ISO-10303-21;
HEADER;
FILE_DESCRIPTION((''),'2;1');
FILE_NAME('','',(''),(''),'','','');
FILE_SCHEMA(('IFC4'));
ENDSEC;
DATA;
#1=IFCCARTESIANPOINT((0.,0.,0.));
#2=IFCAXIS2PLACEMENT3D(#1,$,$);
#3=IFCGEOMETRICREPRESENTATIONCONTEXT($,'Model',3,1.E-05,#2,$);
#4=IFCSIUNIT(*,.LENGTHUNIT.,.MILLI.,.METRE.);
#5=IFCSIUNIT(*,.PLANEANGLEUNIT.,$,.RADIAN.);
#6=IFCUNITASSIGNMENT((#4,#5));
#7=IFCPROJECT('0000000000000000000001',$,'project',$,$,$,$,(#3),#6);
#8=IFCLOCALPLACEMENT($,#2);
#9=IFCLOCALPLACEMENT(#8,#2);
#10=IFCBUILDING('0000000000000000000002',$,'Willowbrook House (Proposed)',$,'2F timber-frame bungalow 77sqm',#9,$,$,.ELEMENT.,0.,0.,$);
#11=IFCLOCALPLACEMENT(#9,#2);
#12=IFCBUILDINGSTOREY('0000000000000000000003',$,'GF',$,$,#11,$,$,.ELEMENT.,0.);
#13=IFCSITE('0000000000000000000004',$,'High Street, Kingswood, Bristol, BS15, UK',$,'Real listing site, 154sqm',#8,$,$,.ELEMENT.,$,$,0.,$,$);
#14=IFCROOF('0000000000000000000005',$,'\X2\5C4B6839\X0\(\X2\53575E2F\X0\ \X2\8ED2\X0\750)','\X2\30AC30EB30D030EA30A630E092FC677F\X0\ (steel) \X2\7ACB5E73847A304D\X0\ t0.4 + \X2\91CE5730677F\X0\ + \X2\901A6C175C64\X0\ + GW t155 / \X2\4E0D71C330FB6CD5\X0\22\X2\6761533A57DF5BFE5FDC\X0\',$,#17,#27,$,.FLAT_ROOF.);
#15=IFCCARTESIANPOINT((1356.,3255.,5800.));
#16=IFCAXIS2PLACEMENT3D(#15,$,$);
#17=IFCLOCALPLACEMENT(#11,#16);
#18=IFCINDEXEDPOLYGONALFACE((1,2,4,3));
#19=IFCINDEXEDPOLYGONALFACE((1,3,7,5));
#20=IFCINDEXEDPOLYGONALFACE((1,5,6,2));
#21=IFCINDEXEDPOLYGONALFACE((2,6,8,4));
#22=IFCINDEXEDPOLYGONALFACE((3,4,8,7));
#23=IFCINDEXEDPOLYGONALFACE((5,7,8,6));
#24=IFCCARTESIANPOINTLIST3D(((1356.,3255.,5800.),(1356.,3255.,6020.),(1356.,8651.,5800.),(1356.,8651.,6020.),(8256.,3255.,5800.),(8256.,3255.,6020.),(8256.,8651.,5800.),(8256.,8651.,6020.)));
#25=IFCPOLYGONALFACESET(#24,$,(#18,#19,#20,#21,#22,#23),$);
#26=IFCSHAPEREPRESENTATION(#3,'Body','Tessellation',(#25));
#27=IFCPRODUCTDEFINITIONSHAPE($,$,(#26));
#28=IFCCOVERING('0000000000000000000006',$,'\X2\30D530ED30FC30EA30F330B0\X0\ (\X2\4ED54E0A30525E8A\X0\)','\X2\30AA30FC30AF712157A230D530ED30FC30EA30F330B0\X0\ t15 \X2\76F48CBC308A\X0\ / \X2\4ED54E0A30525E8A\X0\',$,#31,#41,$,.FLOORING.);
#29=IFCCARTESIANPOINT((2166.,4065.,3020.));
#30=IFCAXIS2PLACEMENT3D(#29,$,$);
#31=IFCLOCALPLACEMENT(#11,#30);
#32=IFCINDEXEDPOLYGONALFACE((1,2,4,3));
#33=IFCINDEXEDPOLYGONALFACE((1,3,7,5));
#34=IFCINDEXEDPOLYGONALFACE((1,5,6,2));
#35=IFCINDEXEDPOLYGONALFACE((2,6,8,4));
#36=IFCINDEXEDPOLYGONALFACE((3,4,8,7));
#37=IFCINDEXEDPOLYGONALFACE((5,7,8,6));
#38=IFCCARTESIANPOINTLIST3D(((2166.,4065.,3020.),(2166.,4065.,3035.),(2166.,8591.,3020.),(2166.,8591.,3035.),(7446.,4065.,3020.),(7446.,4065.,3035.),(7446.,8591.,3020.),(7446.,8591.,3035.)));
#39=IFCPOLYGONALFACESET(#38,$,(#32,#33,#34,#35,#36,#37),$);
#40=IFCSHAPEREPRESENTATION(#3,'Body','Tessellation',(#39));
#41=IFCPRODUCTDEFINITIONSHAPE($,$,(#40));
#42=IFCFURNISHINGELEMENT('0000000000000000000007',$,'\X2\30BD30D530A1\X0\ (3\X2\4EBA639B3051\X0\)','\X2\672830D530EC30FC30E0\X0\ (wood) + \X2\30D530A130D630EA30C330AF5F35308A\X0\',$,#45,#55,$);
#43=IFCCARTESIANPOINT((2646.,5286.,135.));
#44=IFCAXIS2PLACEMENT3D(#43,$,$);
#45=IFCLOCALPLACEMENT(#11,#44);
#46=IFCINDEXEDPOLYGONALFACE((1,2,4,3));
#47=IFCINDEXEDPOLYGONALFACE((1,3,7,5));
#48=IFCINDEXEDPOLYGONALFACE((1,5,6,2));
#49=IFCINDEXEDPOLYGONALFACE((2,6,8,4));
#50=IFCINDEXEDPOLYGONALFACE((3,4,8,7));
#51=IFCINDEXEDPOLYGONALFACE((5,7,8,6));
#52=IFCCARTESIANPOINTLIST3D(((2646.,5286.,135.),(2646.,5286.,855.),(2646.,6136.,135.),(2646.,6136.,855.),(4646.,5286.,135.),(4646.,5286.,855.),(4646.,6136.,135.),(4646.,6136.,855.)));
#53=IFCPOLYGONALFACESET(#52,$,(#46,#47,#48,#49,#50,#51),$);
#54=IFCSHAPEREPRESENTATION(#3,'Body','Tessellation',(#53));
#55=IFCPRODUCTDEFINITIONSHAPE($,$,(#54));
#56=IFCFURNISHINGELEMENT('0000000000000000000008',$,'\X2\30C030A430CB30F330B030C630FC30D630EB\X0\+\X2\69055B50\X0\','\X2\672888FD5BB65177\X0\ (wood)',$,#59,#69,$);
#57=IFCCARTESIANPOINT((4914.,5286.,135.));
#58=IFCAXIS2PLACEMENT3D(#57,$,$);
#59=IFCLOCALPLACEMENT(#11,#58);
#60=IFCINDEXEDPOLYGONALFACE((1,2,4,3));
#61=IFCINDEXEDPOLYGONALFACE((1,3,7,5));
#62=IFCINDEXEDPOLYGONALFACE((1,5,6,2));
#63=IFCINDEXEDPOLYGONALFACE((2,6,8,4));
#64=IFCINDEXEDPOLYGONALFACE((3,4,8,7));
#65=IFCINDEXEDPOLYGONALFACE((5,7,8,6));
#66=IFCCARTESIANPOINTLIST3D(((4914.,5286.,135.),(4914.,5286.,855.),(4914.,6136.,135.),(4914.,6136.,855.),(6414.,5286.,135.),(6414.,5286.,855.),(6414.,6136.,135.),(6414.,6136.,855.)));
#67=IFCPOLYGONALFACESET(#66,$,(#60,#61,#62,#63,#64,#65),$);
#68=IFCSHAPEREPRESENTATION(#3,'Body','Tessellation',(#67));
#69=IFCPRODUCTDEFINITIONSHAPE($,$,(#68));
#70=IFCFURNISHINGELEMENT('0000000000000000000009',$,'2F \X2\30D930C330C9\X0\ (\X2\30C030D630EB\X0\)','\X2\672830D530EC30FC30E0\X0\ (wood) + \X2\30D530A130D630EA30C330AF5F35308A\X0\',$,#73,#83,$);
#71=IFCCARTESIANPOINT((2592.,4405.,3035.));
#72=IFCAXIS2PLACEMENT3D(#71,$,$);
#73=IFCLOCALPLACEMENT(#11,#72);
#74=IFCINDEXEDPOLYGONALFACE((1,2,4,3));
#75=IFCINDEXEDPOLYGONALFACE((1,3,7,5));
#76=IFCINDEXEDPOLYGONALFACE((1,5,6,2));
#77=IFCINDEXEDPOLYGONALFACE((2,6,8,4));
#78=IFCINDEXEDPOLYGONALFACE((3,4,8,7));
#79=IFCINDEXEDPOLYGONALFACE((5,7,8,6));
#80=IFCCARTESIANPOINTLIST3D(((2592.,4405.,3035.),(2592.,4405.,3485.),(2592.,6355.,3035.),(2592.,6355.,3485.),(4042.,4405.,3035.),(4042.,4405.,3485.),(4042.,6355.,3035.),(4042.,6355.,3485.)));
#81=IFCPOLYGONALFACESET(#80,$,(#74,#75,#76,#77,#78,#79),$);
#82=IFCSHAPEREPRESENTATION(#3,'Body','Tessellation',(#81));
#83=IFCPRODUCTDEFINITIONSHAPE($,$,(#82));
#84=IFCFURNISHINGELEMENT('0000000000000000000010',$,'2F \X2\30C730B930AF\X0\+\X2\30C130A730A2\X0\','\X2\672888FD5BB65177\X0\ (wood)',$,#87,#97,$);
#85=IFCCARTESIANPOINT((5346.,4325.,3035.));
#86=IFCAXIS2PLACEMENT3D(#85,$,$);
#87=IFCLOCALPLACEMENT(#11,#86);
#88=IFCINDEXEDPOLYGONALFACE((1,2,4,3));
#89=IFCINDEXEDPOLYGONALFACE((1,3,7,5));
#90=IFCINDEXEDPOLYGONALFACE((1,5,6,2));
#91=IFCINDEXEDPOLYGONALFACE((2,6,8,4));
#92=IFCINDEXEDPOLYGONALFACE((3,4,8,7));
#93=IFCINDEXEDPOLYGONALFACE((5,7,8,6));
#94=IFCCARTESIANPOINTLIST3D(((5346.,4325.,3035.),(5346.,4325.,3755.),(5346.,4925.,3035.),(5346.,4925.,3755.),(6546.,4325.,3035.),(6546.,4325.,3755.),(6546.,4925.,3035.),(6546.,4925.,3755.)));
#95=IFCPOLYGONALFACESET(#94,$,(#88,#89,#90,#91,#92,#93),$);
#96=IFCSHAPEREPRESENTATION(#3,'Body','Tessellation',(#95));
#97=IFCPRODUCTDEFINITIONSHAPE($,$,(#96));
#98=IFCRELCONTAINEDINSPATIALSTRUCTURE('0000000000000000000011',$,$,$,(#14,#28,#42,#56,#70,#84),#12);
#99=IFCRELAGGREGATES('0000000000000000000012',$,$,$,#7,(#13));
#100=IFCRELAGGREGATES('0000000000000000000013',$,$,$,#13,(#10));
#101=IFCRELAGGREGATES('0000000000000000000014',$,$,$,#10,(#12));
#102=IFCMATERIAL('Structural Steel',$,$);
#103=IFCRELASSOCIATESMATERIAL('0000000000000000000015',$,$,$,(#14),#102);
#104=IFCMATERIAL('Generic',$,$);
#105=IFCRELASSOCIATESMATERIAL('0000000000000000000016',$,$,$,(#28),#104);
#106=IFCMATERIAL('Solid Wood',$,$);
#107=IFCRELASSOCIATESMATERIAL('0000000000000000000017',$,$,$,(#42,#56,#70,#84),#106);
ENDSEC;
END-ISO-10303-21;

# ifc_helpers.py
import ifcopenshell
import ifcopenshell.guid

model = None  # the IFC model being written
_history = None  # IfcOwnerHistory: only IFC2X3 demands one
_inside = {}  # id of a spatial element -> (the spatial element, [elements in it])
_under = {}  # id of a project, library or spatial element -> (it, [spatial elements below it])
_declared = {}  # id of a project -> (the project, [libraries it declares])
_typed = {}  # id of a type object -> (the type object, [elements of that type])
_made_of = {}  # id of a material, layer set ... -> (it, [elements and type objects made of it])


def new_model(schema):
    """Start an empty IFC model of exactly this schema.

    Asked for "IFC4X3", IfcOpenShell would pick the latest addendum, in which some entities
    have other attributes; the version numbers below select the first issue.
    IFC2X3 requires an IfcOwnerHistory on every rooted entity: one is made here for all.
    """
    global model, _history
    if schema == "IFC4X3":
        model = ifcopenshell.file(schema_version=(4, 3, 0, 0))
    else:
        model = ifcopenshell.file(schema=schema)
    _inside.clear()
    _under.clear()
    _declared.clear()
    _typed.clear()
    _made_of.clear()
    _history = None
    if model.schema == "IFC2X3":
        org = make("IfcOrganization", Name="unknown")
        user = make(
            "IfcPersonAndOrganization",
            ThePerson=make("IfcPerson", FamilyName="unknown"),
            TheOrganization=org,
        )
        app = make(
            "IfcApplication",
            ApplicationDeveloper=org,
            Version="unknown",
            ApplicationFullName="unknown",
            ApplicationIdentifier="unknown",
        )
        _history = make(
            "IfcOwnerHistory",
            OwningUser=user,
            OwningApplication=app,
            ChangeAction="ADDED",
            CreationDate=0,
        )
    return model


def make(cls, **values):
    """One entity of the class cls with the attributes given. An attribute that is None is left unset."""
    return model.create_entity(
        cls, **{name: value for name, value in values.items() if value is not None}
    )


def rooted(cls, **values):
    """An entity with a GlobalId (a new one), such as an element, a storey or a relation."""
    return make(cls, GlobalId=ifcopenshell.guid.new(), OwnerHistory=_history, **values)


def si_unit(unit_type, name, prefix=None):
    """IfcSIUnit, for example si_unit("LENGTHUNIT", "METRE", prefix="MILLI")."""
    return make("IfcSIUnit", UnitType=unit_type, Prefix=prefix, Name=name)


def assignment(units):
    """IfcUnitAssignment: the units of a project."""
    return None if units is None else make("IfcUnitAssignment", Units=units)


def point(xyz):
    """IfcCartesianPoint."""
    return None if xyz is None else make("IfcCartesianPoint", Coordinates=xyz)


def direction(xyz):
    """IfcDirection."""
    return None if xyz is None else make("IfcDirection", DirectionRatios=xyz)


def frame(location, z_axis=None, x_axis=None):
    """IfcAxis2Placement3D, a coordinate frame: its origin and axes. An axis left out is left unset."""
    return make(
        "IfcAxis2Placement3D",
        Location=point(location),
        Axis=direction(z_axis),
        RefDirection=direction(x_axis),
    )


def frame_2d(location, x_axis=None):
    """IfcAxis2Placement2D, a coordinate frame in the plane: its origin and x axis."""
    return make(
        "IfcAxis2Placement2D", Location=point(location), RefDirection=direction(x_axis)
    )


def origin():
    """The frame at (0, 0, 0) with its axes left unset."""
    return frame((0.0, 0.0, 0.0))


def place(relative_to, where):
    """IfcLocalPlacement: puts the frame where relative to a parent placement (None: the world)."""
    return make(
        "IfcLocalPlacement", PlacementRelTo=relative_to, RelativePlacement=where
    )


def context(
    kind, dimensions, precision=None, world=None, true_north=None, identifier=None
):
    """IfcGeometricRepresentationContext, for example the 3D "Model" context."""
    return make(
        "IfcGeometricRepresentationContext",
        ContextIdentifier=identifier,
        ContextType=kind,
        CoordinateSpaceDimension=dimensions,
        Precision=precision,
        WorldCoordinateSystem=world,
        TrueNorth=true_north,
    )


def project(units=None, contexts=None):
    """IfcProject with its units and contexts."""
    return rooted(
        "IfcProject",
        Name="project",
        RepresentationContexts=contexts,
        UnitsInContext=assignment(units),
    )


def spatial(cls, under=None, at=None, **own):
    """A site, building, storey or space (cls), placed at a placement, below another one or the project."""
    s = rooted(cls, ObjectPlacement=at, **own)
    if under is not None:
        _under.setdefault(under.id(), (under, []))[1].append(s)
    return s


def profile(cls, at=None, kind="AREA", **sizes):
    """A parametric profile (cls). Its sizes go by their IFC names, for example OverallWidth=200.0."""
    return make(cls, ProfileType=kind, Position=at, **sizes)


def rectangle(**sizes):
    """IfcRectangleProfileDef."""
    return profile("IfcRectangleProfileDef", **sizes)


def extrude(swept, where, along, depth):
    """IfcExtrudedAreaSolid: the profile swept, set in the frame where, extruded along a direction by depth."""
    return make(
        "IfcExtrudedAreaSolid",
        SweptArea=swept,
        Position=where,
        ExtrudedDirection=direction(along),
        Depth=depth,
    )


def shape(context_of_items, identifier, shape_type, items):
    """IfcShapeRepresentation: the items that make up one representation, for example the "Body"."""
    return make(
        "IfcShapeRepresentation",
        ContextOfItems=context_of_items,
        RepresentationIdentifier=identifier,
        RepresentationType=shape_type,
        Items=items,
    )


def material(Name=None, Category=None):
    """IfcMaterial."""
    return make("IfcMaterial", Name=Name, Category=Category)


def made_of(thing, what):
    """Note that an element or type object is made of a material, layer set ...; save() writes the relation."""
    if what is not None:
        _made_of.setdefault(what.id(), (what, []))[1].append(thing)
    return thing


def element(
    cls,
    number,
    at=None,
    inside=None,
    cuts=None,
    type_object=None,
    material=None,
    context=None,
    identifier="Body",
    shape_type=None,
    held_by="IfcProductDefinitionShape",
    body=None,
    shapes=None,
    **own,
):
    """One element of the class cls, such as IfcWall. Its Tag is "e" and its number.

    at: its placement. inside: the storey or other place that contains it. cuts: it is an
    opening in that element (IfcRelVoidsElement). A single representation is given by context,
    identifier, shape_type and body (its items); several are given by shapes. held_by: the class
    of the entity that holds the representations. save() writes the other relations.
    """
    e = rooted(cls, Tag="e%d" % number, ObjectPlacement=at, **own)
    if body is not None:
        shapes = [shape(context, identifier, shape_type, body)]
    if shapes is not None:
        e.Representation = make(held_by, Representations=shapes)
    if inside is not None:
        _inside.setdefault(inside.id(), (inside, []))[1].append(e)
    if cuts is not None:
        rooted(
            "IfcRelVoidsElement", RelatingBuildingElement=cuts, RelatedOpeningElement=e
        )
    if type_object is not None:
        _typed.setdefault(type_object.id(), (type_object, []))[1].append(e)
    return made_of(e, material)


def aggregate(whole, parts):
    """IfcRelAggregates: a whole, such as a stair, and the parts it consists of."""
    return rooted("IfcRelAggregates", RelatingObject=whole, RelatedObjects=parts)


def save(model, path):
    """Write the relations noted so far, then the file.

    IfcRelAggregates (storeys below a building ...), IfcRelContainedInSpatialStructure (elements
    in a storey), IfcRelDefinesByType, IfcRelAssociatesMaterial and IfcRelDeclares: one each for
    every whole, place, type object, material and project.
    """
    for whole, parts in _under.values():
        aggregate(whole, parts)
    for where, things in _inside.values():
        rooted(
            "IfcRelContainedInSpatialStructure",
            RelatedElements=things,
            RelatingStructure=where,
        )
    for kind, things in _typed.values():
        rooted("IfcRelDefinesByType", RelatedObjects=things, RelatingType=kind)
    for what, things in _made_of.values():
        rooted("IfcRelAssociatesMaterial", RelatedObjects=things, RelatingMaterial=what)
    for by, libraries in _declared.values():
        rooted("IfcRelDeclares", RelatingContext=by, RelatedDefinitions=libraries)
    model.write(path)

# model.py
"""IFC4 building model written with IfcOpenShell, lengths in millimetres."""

from ifc_helpers import new_model, si_unit, frame, frame_2d, origin, place, context, project, spatial, rectangle, extrude, material, element, save


model = new_model("IFC4")

# Units and contexts
model_context = context("Model", 3, precision=1e-05, world=origin())
ifc_project = project(units=[si_unit("LENGTHUNIT", "METRE", prefix="MILLI"), si_unit("PLANEANGLEUNIT", "RADIAN")], contexts=[model_context])

# Site, building, storey
site_placement = place(None, origin())
site = spatial("IfcSite", under=ifc_project, at=site_placement, Name="High Street, Kingswood, Bristol, BS15, UK", ObjectType="Real listing site, 154sqm", CompositionType="ELEMENT", RefElevation=0.0)
building_placement = place(site_placement, origin())
building = spatial("IfcBuilding", under=site, at=building_placement, Name="Willowbrook House (Proposed)", ObjectType="2F timber-frame bungalow 77sqm", CompositionType="ELEMENT", ElevationOfRefHeight=0.0, ElevationOfTerrain=0.0)
storey_placement = place(building_placement, origin())
storey = spatial("IfcBuildingStorey", under=building, at=storey_placement, Name="GF", CompositionType="ELEMENT", Elevation=0.0)

# Shared definitions
ifc_material_1 = material(Name="Solid Wood")

# Roof
ifc_material_2 = material(Name="Structural Steel")
for number, where, name in (
    (1, (1356.0, 3255.0, 5800.0), "屋根(南帯 軒750)"),
):
    element("IfcRoof", number, at=place(storey_placement, frame(where)), inside=storey, material=ifc_material_2, Name=name, Description="ガルバリウム鋼板 (steel) 立平葺き t0.4 + 野地板 + 通気層 + GW t155 / 不燃・法22条区域対応", PredefinedType="FLAT_ROOF", context=model_context, shape_type="SweptSolid", body=[
        extrude(rectangle(XDim=6900.0, YDim=5396.0, at=frame_2d((3450.0, 2698.0))), frame((1356.0, 3255.0, 5800.0)), (0.0, 0.0, 1.0), 220.0),
    ])

# Covering
ifc_material_3 = material(Name="Generic")
covering_placement = place(storey_placement, frame((2166.0, 4065.0, 3020.0)))
element("IfcCovering", 2, at=covering_placement, inside=storey, material=ifc_material_3, Name="フローリング (仕上げ床)", Description="オーク無垢フローリング t15 直貼り / 仕上げ床", PredefinedType="FLOORING", context=model_context, shape_type="SweptSolid", body=[
    extrude(rectangle(XDim=5280.0, YDim=4526.0, at=frame_2d((2640.0, 2263.0))), frame((2166.0, 4065.0, 3020.0)), (0.0, 0.0, 1.0), 15.0),
])

# Furnishing elements
furnishing_1_placement = place(storey_placement, frame((2646.0, 5286.0, 135.0)))
element("IfcFurnishingElement", 3, at=furnishing_1_placement, inside=storey, material=ifc_material_1, Name="ソファ (3人掛け)", Description="木フレーム (wood) + ファブリック張り", context=model_context, shape_type="SweptSolid", body=[
    extrude(rectangle(XDim=2000.0, YDim=850.0, at=frame_2d((1000.0, 425.0))), frame((2646.0, 5286.0, 135.0)), (0.0, 0.0, 1.0), 720.0),
])
furnishing_2_placement = place(storey_placement, frame((4914.0, 5286.0, 135.0)))
element("IfcFurnishingElement", 4, at=furnishing_2_placement, inside=storey, material=ifc_material_1, Name="ダイニングテーブル+椅子", Description="木製家具 (wood)", context=model_context, shape_type="SweptSolid", body=[
    extrude(rectangle(XDim=1500.0, YDim=850.0, at=frame_2d((750.0, 425.0))), frame((4914.0, 5286.0, 135.0)), (0.0, 0.0, 1.0), 720.0),
])
furnishing_3_placement = place(storey_placement, frame((2592.0, 4405.0, 3035.0)))
element("IfcFurnishingElement", 5, at=furnishing_3_placement, inside=storey, material=ifc_material_1, Name="2F ベッド (ダブル)", Description="木フレーム (wood) + ファブリック張り", context=model_context, shape_type="SweptSolid", body=[
    extrude(rectangle(XDim=1450.0, YDim=1950.0, at=frame_2d((725.0, 975.0))), frame((2592.0, 4405.0, 3035.0)), (0.0, 0.0, 1.0), 450.0),
])
furnishing_4_placement = place(storey_placement, frame((5346.0, 4325.0, 3035.0)))
element("IfcFurnishingElement", 6, at=furnishing_4_placement, inside=storey, material=ifc_material_1, Name="2F デスク+チェア", Description="木製家具 (wood)", context=model_context, shape_type="SweptSolid", body=[
    extrude(rectangle(XDim=1200.0, YDim=600.0, at=frame_2d((600.0, 300.0))), frame((5346.0, 4325.0, 3035.0)), (0.0, 0.0, 1.0), 720.0),
])

save(model, "model.ifc")
